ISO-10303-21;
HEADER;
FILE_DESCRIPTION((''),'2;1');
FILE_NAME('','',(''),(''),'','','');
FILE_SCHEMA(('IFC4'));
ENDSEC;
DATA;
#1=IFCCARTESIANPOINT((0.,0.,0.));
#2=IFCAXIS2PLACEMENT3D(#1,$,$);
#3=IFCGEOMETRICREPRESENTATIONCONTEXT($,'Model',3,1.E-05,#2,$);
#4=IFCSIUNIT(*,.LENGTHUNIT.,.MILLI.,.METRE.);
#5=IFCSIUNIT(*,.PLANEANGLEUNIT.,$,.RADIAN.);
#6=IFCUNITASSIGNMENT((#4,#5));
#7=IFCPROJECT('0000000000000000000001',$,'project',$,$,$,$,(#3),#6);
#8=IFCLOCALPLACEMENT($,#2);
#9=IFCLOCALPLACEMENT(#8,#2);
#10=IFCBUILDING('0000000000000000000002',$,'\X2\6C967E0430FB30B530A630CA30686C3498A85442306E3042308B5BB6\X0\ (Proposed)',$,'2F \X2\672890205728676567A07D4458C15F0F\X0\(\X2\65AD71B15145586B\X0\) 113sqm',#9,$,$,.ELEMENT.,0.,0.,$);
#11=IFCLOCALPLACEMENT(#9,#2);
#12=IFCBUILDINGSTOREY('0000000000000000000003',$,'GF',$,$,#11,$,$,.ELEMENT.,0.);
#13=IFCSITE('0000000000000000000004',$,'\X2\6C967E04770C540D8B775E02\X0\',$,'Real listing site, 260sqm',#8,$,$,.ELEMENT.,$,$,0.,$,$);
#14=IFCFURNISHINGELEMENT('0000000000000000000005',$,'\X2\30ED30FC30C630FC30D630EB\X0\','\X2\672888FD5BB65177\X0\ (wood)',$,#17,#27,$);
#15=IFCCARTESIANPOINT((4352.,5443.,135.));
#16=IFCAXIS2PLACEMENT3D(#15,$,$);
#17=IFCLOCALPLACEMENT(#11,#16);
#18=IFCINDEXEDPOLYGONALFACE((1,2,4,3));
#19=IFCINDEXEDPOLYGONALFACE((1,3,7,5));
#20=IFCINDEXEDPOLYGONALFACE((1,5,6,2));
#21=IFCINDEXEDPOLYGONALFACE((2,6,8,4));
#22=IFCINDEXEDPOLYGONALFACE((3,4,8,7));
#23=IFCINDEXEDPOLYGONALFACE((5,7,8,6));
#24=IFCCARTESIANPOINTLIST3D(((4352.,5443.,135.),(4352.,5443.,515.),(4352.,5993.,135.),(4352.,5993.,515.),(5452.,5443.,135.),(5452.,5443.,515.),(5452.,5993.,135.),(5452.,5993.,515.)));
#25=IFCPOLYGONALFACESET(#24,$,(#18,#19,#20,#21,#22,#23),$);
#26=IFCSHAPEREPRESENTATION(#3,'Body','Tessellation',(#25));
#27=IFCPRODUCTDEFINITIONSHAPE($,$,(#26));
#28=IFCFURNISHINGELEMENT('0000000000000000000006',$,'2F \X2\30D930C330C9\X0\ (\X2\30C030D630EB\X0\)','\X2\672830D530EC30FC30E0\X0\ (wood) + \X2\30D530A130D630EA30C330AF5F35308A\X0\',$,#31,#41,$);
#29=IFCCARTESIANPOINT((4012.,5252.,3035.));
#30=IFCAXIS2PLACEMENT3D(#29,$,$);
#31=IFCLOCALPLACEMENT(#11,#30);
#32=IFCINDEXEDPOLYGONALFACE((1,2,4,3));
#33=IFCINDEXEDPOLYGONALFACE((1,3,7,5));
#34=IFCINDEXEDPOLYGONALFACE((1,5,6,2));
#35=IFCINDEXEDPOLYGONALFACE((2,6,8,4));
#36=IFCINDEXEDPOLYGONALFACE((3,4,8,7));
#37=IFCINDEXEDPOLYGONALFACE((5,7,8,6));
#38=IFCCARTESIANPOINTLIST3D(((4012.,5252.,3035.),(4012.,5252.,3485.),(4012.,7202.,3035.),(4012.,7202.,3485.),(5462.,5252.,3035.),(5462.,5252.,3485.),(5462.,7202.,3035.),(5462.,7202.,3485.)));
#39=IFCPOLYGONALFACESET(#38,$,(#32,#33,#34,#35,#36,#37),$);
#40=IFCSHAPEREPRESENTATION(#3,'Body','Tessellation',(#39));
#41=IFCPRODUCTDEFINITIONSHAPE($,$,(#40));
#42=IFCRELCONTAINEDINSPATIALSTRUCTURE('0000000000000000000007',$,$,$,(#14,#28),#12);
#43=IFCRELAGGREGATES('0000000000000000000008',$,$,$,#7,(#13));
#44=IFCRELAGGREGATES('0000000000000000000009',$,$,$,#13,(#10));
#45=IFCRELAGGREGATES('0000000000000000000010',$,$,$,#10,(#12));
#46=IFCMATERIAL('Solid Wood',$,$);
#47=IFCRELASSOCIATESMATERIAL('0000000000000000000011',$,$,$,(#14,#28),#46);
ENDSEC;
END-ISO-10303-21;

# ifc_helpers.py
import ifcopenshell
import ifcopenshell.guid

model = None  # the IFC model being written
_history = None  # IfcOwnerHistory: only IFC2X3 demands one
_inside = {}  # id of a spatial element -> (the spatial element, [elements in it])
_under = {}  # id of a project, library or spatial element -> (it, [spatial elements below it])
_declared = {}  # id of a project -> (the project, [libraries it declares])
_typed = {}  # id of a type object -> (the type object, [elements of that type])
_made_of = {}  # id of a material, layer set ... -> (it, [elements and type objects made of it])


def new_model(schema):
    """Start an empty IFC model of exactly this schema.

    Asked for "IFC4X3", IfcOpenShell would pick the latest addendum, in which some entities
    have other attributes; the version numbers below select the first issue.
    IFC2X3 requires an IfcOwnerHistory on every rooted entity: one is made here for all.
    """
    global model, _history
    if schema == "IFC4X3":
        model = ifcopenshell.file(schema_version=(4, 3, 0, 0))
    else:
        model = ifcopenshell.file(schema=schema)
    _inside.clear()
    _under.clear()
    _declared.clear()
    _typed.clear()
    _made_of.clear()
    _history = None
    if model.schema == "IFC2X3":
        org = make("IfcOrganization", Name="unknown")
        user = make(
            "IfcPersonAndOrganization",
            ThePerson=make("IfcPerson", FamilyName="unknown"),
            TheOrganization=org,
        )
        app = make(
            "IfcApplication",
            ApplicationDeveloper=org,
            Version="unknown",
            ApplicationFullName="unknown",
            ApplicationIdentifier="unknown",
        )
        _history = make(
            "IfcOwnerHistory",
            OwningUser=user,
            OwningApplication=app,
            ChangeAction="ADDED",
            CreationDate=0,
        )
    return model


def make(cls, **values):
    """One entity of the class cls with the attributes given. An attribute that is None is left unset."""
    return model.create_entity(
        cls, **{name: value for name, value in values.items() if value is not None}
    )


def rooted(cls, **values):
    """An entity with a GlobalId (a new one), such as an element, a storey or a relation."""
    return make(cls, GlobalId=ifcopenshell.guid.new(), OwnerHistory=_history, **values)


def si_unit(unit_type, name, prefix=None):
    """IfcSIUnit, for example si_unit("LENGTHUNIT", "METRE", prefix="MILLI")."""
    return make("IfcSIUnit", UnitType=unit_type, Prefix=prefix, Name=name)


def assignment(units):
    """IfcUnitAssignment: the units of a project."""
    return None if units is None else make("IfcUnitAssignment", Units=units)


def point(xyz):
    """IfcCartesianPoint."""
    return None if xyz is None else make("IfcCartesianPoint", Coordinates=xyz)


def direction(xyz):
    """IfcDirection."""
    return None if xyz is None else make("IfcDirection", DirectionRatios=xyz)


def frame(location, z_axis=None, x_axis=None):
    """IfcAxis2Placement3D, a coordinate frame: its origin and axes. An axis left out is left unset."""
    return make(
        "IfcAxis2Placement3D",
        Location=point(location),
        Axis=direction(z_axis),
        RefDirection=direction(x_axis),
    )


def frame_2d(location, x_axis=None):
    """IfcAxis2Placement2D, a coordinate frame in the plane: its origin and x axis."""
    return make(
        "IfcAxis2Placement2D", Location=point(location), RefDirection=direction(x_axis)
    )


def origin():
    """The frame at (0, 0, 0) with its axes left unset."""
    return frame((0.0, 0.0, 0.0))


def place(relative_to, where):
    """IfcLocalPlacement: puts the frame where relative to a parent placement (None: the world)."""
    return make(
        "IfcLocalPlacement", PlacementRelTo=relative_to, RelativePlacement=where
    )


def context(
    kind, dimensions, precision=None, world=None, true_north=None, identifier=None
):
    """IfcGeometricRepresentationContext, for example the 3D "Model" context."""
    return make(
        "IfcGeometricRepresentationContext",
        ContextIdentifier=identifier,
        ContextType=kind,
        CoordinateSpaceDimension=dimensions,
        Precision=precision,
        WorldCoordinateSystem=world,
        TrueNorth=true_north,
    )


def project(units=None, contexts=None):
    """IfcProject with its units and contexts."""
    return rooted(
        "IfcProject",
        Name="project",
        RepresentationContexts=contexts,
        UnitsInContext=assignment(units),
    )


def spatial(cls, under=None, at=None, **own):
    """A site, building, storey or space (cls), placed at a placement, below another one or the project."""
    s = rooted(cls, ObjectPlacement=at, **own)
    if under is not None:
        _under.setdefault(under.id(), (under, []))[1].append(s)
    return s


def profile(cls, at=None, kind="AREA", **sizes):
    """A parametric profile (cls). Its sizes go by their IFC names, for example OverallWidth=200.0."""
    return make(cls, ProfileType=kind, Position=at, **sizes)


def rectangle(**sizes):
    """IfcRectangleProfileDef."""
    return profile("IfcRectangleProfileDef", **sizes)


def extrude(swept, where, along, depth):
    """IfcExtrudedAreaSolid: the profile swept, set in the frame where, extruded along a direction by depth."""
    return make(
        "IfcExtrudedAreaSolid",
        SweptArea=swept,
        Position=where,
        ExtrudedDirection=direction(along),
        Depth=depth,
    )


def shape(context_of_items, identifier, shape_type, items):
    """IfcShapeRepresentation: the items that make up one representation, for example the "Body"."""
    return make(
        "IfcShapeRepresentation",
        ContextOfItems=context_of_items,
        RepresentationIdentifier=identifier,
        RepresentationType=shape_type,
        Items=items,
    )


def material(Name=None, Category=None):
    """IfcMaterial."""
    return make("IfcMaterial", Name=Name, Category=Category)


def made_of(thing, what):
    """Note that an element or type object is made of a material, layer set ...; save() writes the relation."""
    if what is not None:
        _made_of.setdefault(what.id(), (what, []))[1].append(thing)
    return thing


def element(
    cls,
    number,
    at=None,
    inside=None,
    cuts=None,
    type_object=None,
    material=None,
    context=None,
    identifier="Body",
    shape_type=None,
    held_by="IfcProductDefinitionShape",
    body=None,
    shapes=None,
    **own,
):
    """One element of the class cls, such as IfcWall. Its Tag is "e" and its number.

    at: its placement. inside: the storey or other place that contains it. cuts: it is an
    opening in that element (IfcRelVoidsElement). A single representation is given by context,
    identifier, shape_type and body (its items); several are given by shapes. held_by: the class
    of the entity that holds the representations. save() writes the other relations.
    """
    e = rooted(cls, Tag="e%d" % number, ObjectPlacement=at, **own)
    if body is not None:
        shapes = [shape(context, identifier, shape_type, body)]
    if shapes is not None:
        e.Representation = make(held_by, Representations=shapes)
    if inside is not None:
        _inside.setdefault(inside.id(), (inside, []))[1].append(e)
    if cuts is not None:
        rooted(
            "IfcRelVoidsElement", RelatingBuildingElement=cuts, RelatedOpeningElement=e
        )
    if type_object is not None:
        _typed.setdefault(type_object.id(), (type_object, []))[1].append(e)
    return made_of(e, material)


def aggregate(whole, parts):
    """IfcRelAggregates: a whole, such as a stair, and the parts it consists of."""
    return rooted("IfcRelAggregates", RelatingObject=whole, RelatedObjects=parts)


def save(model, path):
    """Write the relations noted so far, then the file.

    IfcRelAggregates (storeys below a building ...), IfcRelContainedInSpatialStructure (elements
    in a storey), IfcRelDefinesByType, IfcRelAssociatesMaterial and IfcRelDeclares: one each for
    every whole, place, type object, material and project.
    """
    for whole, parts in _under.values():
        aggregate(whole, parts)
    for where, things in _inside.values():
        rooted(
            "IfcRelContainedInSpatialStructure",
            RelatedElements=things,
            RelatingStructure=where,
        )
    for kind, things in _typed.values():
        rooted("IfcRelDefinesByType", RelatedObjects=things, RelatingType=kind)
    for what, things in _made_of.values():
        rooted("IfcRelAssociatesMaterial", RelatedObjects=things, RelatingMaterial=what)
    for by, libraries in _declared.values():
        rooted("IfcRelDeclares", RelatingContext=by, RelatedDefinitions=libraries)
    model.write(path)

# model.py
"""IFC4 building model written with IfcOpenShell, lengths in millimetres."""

from ifc_helpers import new_model, si_unit, frame, frame_2d, origin, place, context, project, spatial, rectangle, extrude, material, element, save


model = new_model("IFC4")

# Units and contexts
model_context = context("Model", 3, precision=1e-05, world=origin())
ifc_project = project(units=[si_unit("LENGTHUNIT", "METRE", prefix="MILLI"), si_unit("PLANEANGLEUNIT", "RADIAN")], contexts=[model_context])

# Site, building, storey
site_placement = place(None, origin())
site = spatial("IfcSite", under=ifc_project, at=site_placement, Name="沖縄県名護市", ObjectType="Real listing site, 260sqm", CompositionType="ELEMENT", RefElevation=0.0)
building_placement = place(site_placement, origin())
building = spatial("IfcBuilding", under=site, at=building_placement, Name="沖縄・サウナと水風呂のある家 (Proposed)", ObjectType="2F 木造在来枠組壁式(断熱充填) 113sqm", CompositionType="ELEMENT", ElevationOfRefHeight=0.0, ElevationOfTerrain=0.0)
storey_placement = place(building_placement, origin())
storey = spatial("IfcBuildingStorey", under=building, at=storey_placement, Name="GF", CompositionType="ELEMENT", Elevation=0.0)

# Shared definitions
ifc_material_1 = material(Name="Solid Wood")

# Furnishing elements
furnishing_1_placement = place(storey_placement, frame((4352.0, 5443.0, 135.0)))
element("IfcFurnishingElement", 1, at=furnishing_1_placement, inside=storey, material=ifc_material_1, Name="ローテーブル", Description="木製家具 (wood)", context=model_context, shape_type="SweptSolid", body=[
    extrude(rectangle(XDim=1100.0, YDim=550.0, at=frame_2d((550.0, 275.0))), frame((4352.0, 5443.0, 135.0)), (0.0, 0.0, 1.0), 380.0),
])
furnishing_2_placement = place(storey_placement, frame((4012.0, 5252.0, 3035.0)))
element("IfcFurnishingElement", 2, at=furnishing_2_placement, inside=storey, material=ifc_material_1, Name="2F ベッド (ダブル)", Description="木フレーム (wood) + ファブリック張り", context=model_context, shape_type="SweptSolid", body=[
    extrude(rectangle(XDim=1450.0, YDim=1950.0, at=frame_2d((725.0, 975.0))), frame((4012.0, 5252.0, 3035.0)), (0.0, 0.0, 1.0), 450.0),
])

save(model, "model.ifc")
